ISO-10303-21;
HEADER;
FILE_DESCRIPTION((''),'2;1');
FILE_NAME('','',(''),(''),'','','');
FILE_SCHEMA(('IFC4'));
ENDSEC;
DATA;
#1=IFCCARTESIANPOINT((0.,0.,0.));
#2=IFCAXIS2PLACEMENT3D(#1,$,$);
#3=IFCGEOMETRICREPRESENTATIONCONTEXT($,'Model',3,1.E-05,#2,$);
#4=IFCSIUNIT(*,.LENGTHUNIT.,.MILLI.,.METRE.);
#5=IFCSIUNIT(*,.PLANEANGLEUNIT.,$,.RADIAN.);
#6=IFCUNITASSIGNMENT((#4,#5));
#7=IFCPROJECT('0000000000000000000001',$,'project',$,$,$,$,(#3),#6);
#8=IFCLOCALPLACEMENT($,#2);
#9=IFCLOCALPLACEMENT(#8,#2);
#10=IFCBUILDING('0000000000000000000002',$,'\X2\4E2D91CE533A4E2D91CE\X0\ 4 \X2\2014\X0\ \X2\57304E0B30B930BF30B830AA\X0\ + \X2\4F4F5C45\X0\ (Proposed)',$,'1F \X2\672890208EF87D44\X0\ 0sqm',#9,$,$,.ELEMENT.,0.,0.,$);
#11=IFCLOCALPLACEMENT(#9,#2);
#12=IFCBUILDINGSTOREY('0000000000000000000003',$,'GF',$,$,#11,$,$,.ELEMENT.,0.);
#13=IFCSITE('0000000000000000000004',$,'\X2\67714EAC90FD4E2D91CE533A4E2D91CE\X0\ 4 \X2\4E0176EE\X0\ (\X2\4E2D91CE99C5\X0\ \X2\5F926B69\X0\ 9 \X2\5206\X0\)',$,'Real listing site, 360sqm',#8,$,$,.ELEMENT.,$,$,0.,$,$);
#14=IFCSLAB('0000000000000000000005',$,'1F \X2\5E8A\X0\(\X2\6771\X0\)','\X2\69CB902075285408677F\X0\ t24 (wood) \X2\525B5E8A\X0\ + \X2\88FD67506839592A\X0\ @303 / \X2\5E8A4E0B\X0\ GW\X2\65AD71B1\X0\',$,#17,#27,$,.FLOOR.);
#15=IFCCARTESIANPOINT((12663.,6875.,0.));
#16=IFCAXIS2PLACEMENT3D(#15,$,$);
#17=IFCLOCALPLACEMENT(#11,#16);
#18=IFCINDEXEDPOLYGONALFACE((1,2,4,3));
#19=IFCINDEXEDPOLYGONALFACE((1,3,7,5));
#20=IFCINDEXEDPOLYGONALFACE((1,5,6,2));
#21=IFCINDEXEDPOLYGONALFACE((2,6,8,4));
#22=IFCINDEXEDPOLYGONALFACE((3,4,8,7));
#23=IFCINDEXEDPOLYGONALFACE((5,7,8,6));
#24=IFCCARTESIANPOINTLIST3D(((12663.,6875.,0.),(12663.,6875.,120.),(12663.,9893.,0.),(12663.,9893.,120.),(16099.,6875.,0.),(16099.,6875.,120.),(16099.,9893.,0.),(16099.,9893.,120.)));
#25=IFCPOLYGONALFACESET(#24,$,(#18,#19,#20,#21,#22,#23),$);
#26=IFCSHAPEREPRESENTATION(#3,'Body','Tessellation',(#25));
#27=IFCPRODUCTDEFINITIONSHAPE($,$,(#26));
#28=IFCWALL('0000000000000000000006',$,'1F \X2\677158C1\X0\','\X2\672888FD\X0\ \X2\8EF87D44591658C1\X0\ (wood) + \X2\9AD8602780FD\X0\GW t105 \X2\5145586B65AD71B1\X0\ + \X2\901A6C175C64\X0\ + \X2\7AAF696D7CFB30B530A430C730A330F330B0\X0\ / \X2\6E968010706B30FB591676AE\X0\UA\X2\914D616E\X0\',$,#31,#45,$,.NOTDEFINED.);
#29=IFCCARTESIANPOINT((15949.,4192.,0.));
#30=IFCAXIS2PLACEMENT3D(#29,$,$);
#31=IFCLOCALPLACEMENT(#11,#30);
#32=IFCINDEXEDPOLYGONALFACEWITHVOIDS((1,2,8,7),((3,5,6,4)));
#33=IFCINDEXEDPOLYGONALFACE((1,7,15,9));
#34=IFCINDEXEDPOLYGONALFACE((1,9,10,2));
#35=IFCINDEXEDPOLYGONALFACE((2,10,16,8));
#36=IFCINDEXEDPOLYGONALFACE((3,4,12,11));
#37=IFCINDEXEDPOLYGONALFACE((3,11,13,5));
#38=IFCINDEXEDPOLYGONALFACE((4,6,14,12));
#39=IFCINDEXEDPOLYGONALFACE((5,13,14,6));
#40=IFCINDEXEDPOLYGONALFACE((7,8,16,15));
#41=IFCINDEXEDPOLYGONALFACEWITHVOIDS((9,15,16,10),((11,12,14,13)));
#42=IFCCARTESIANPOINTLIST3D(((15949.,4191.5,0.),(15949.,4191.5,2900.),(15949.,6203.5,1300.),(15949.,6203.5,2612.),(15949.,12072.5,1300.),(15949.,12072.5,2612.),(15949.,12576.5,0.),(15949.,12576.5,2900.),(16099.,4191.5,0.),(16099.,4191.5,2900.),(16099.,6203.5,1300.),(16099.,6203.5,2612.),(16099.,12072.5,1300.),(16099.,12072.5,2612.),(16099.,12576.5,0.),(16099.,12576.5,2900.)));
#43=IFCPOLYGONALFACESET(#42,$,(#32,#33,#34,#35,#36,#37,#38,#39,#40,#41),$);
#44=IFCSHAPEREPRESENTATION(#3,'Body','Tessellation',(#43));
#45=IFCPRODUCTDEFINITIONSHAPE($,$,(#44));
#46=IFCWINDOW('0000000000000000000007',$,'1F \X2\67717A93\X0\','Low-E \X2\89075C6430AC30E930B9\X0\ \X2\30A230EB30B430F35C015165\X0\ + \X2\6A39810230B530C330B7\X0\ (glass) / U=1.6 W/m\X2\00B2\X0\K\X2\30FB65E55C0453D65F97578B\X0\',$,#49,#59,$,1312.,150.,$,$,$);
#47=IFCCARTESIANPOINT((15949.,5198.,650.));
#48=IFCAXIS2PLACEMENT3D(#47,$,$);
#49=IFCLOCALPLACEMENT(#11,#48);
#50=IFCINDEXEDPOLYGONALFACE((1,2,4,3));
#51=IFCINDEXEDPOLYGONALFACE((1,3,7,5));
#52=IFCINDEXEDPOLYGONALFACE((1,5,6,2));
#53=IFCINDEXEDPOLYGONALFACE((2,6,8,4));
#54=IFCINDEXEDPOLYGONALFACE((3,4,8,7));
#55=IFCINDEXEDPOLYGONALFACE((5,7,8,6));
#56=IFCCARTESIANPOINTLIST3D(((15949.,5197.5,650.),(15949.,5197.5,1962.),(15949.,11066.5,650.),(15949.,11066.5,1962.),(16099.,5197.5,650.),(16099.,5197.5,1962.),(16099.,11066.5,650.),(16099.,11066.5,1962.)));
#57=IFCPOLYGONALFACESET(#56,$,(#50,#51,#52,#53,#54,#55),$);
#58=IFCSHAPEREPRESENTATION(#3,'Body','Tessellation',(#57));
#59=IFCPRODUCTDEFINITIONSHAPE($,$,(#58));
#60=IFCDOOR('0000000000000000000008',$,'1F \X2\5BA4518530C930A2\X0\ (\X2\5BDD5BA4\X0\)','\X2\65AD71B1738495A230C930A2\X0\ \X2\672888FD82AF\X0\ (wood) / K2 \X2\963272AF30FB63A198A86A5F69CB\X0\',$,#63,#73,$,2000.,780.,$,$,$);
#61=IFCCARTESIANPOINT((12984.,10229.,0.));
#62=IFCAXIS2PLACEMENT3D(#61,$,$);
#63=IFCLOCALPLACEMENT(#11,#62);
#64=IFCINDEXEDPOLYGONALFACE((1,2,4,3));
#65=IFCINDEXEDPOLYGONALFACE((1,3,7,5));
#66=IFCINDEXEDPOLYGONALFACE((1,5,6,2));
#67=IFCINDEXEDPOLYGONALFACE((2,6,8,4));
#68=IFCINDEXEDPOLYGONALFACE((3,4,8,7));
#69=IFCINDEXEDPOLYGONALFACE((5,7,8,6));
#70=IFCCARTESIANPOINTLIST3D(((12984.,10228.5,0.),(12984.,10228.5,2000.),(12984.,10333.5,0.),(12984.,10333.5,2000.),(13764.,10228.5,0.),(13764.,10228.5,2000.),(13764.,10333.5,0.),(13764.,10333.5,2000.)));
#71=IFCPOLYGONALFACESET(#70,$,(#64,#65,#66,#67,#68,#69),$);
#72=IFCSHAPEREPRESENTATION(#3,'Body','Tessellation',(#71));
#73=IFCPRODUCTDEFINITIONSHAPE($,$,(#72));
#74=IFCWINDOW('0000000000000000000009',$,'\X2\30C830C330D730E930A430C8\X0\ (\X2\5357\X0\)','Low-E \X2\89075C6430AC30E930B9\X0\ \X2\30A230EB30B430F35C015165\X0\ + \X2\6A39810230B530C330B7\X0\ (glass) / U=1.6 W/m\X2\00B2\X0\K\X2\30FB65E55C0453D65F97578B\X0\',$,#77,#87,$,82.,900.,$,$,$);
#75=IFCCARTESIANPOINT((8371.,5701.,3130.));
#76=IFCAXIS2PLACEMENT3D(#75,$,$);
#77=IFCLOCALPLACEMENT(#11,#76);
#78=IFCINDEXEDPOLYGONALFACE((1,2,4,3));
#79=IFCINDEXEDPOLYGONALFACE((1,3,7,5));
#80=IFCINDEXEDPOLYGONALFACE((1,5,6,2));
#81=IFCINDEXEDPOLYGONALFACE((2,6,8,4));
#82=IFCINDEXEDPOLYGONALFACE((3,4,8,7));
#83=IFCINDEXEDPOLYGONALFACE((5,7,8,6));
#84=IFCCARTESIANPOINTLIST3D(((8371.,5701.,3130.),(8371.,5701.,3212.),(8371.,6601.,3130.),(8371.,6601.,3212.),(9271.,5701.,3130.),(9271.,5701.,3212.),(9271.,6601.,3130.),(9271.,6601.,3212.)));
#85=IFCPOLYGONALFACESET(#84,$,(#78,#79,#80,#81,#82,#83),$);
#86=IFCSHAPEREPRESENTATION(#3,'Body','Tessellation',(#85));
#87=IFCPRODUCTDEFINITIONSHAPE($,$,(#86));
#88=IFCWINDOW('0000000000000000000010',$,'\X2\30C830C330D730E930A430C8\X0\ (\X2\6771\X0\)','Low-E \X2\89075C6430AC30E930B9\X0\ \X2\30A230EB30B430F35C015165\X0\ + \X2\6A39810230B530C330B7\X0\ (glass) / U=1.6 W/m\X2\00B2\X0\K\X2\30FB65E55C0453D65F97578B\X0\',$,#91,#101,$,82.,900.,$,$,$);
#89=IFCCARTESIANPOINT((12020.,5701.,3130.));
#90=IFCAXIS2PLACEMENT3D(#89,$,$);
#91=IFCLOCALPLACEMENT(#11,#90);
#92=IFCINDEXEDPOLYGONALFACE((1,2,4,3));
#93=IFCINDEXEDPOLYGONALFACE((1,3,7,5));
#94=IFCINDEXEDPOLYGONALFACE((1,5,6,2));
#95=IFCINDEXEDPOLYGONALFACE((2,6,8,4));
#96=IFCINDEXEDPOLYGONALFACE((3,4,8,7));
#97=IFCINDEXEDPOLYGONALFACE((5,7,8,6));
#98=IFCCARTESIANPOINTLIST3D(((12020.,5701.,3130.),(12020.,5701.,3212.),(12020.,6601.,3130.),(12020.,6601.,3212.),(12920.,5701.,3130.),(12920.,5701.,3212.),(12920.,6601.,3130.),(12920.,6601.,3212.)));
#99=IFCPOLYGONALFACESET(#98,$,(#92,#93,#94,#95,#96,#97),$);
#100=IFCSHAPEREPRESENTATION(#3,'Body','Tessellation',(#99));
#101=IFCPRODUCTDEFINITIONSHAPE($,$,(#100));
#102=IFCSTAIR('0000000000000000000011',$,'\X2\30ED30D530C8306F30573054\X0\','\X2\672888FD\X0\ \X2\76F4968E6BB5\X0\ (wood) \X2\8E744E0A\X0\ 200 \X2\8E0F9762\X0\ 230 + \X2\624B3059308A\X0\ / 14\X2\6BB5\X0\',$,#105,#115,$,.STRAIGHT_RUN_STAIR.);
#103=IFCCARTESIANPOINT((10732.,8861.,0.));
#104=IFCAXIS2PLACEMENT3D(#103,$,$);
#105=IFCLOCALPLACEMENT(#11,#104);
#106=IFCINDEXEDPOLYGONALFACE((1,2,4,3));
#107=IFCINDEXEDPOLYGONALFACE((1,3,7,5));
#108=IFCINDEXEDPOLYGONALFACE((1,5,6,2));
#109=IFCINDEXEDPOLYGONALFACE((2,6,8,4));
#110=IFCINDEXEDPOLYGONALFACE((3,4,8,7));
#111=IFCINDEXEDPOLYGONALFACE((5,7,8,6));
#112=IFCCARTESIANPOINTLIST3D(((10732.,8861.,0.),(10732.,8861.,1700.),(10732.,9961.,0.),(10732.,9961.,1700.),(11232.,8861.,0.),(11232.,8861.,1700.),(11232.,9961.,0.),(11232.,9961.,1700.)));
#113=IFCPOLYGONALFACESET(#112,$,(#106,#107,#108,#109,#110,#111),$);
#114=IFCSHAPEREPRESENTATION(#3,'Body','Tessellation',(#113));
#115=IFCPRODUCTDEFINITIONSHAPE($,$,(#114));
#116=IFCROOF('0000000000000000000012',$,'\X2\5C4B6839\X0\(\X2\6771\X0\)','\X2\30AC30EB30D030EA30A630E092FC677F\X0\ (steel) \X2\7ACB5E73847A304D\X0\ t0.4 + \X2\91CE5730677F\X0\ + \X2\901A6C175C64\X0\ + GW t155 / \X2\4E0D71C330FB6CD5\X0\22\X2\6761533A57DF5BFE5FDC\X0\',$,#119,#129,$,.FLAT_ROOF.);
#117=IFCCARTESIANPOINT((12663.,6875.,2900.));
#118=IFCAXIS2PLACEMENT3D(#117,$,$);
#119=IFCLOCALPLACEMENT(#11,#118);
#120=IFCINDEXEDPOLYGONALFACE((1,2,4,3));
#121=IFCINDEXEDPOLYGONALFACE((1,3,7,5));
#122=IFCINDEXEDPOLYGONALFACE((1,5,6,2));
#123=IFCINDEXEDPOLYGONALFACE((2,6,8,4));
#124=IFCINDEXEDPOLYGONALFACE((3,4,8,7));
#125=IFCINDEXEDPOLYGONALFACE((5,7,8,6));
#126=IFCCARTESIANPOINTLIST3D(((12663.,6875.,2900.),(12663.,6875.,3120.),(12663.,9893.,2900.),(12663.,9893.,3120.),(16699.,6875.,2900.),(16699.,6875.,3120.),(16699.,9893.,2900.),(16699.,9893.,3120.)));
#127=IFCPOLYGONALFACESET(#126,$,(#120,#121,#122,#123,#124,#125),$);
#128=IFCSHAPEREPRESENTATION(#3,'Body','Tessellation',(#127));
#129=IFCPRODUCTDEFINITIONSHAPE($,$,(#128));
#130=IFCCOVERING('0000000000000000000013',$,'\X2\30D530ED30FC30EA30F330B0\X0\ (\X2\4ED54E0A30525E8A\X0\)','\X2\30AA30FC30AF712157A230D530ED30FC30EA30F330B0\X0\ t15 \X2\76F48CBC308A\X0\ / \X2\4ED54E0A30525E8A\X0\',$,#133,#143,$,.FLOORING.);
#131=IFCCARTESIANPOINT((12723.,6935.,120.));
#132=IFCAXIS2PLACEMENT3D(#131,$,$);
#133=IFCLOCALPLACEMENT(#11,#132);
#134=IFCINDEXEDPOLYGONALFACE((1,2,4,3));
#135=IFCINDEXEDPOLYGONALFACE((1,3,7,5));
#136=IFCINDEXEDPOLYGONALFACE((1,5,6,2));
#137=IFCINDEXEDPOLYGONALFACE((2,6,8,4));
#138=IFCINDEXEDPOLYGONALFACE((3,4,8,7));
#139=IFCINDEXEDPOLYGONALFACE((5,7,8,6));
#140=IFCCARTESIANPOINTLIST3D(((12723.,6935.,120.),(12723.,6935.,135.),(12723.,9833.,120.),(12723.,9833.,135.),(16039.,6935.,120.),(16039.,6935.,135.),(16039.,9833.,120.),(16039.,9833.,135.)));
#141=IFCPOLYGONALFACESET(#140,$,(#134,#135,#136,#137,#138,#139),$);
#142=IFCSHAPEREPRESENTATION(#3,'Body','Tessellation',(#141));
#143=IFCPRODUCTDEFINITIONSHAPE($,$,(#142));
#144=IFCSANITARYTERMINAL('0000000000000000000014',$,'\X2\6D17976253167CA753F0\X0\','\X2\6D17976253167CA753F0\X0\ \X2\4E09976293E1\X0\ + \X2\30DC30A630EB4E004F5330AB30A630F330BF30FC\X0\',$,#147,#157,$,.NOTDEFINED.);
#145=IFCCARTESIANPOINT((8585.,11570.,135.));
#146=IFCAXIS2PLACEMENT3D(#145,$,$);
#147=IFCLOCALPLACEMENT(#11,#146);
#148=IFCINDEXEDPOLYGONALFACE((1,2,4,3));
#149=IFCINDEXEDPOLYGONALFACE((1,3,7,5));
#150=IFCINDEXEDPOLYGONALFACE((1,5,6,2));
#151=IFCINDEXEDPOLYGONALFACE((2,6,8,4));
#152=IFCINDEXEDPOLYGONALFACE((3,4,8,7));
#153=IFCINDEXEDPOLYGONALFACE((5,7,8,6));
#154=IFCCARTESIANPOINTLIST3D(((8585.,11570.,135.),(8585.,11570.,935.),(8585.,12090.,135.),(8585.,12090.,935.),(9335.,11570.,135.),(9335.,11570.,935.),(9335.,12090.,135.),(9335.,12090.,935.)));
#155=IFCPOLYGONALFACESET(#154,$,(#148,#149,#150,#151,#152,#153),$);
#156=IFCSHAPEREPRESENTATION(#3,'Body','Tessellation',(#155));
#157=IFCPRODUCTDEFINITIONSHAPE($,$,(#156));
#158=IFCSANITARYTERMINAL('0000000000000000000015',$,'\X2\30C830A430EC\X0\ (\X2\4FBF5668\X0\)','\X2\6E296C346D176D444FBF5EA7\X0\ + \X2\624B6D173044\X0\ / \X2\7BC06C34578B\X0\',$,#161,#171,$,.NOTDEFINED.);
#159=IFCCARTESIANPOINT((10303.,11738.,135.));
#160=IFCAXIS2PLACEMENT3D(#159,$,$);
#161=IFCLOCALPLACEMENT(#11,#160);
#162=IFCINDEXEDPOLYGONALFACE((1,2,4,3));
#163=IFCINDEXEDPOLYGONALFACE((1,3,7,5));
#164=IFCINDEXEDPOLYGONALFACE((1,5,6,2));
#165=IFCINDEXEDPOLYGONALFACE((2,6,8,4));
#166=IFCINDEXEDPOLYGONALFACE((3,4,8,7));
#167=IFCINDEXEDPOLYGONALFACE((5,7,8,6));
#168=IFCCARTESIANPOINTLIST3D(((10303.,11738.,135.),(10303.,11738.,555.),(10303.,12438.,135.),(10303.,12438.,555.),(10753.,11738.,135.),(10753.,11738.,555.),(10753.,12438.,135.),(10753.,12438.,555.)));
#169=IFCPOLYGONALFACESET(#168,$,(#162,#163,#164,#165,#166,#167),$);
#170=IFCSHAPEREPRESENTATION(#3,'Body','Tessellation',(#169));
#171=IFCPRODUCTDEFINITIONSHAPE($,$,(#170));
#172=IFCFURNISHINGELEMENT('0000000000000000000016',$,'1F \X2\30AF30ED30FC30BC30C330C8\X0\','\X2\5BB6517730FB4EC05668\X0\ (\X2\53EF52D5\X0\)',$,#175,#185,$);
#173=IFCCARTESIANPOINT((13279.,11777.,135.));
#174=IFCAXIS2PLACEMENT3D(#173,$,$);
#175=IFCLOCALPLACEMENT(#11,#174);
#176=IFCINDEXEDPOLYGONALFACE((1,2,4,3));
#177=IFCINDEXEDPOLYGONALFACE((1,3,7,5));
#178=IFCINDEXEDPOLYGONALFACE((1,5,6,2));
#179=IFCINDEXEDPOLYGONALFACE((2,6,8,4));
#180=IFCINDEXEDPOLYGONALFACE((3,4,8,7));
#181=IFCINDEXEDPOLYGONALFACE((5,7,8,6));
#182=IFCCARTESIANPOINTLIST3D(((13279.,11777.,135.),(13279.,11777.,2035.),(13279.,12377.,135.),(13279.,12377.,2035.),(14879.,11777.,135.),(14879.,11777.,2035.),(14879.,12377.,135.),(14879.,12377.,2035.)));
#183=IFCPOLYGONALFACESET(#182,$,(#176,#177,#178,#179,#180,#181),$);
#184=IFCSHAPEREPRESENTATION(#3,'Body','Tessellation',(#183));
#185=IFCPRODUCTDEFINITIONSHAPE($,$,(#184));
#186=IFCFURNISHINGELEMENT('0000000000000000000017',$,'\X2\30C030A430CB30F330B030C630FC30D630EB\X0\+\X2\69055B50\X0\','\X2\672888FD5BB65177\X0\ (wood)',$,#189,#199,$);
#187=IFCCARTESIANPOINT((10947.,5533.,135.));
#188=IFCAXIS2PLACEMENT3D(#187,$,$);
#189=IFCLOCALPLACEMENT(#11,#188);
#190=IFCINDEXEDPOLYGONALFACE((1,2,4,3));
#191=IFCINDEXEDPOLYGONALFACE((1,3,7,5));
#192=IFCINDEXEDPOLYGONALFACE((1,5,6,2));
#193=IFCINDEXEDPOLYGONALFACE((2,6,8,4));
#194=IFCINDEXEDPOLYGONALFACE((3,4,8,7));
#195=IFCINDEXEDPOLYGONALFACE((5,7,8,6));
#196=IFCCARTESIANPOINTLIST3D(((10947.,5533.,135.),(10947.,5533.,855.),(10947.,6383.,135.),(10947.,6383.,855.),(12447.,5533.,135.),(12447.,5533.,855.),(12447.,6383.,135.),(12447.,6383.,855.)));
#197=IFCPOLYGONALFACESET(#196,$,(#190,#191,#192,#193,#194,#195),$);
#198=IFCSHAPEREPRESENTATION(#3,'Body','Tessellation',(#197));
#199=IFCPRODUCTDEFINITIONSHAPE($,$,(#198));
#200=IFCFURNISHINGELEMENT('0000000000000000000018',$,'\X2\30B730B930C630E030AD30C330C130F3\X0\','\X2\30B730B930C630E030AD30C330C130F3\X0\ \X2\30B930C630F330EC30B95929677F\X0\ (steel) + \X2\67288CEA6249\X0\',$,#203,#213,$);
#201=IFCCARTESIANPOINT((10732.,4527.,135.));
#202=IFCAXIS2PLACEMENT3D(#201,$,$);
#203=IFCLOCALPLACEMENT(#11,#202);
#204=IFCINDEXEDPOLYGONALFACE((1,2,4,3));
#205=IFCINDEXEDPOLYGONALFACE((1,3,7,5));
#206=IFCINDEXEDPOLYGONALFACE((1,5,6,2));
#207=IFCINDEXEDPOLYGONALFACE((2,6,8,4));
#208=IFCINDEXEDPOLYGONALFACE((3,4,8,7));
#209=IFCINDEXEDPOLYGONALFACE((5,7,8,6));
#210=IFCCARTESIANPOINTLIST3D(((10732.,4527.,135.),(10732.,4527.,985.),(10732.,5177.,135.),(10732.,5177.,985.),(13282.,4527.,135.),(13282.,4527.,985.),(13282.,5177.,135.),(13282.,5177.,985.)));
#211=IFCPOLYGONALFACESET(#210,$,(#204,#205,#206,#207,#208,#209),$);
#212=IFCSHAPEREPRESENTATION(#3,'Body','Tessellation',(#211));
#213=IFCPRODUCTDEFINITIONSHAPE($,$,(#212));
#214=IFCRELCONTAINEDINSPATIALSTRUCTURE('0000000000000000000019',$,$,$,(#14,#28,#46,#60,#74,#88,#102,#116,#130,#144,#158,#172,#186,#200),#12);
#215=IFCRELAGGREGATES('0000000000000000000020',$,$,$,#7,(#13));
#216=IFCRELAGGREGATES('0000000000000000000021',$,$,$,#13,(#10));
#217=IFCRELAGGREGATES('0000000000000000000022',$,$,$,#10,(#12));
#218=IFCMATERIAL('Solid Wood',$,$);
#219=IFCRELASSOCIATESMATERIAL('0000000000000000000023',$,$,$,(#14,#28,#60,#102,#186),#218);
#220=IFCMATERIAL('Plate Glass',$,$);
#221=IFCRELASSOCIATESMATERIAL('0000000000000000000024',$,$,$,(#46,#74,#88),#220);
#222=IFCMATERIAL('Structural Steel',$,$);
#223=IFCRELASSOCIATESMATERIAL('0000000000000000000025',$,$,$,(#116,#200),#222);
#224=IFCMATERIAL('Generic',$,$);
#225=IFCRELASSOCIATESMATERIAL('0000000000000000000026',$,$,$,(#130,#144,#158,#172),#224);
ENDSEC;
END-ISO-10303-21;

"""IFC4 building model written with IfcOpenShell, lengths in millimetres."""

from ifc_helpers import new_model, si_unit, frame, frame_2d, origin, place, context, project, spatial, rectangle, extrude, material, element, fill, save


model = new_model("IFC4")

# Units and contexts
model_context = context("Model", 3, precision=1e-05, world=origin())
ifc_project = project(units=[si_unit("LENGTHUNIT", "METRE", prefix="MILLI"), si_unit("PLANEANGLEUNIT", "RADIAN")], contexts=[model_context])

# Site, building, storey
site_placement = place(None, origin())
site = spatial("IfcSite", under=ifc_project, at=site_placement, Name="東京都中野区中野 4 丁目 (中野駅 徒歩 9 分)", ObjectType="Real listing site, 360sqm", CompositionType="ELEMENT", RefElevation=0.0)
building_placement = place(site_placement, origin())
building = spatial("IfcBuilding", under=site, at=building_placement, Name="中野区中野 4 — 地下スタジオ + 住居 (Proposed)", ObjectType="1F 木造軸組 0sqm", CompositionType="ELEMENT", ElevationOfRefHeight=0.0, ElevationOfTerrain=0.0)
storey_placement = place(building_placement, origin())
storey = spatial("IfcBuildingStorey", under=building, at=storey_placement, Name="GF", CompositionType="ELEMENT", Elevation=0.0)

# Slab
ifc_material_1 = material(Name="Solid Wood")
slab_1_placement = place(storey_placement, frame((12663.0, 6875.0, 0.0)))
element("IfcSlab", 1, at=slab_1_placement, inside=storey, material=ifc_material_1, Name="1F 床(東)", Description="構造用合板 t24 (wood) 剛床 + 製材根太 @303 / 床下 GW断熱", PredefinedType="FLOOR", context=model_context, shape_type="SweptSolid", body=[
    extrude(rectangle(XDim=3436.0, YDim=3018.0, at=frame_2d((1718.0, 1509.0))), frame((12663.0, 6875.0, 0.0)), (0.0, 0.0, 1.0), 120.0),
])

# Wall, opening, window
wall_1_placement = place(storey_placement, frame((15949.0, 4192.0, 0.0)))
wall_1 = element("IfcWall", 2, at=wall_1_placement, inside=storey, material=ifc_material_1, Name="1F 東壁", Description="木製 軸組外壁 (wood) + 高性能GW t105 充填断熱 + 通気層 + 窯業系サイディング / 準耐火・外皮UA配慮", PredefinedType="NOTDEFINED", context=model_context, shape_type="SweptSolid", body=[
    extrude(rectangle(XDim=150.0, YDim=8385.0, at=frame_2d((75.0, 4192.0))), frame((15949.0, 4192.0, 0.0)), (0.0, 0.0, 1.0), 2900.0),
])
opening_1_placement = place(storey_placement, frame((15949.0, 5198.0, 650.0)))
opening_1 = element("IfcOpeningElement", 3, at=opening_1_placement, cuts=wall_1, PredefinedType="NOTDEFINED", context=model_context, shape_type="SweptSolid", body=[
    extrude(rectangle(XDim=150.0, YDim=5869.0, at=frame_2d((75.0, 2934.0))), frame((15949.0, 5198.0, 650.0)), (0.0, 0.0, 1.0), 1312.0),
])
ifc_material_2 = material(Name="Plate Glass")
window_1_placement = place(storey_placement, frame((15949.0, 5198.0, 650.0)))
window_1 = element("IfcWindow", 4, at=window_1_placement, inside=storey, material=ifc_material_2, Name="1F 東窓", Description="Low-E 複層ガラス アルゴン封入 + 樹脂サッシ (glass) / U=1.6 W/m²K・日射取得型", OverallHeight=1312.0, OverallWidth=150.0, context=model_context, shape_type="SweptSolid", body=[
    extrude(rectangle(XDim=150.0, YDim=5869.0, at=frame_2d((75.0, 2934.0))), frame((15949.0, 5198.0, 650.0)), (0.0, 0.0, 1.0), 1312.0),
])
fill(opening_1, window_1)

# Door
door_placement = place(storey_placement, frame((12984.0, 10229.0, 0.0)))
element("IfcDoor", 5, at=door_placement, inside=storey, material=ifc_material_1, Name="1F 室内ドア (寝室)", Description="断熱玄関ドア 木製芯 (wood) / K2 防犯・採風機構", OverallHeight=2000.0, OverallWidth=780.0, context=model_context, shape_type="SweptSolid", body=[
    extrude(rectangle(XDim=780.0, YDim=105.0, at=frame_2d((390.0, 52.0))), frame((12984.0, 10229.0, 0.0)), (0.0, 0.0, 1.0), 2000.0),
])

# Windows
window_2_placement = place(storey_placement, frame((8371.0, 5701.0, 3130.0)))
element("IfcWindow", 6, at=window_2_placement, inside=storey, material=ifc_material_2, Name="トップライト (南)", Description="Low-E 複層ガラス アルゴン封入 + 樹脂サッシ (glass) / U=1.6 W/m²K・日射取得型", OverallHeight=82.0, OverallWidth=900.0, context=model_context, shape_type="SweptSolid", body=[
    extrude(rectangle(XDim=900.0, YDim=900.0, at=frame_2d((450.0, 450.0))), frame((8371.0, 5701.0, 3130.0)), (0.0, 0.0, 1.0), 82.0),
])
window_3_placement = place(storey_placement, frame((12020.0, 5701.0, 3130.0)))
element("IfcWindow", 7, at=window_3_placement, inside=storey, material=ifc_material_2, Name="トップライト (東)", Description="Low-E 複層ガラス アルゴン封入 + 樹脂サッシ (glass) / U=1.6 W/m²K・日射取得型", OverallHeight=82.0, OverallWidth=900.0, context=model_context, shape_type="SweptSolid", body=[
    extrude(rectangle(XDim=900.0, YDim=900.0, at=frame_2d((450.0, 450.0))), frame((12020.0, 5701.0, 3130.0)), (0.0, 0.0, 1.0), 82.0),
])

# Stair
stair_placement = place(storey_placement, frame((10732.0, 8861.0, 0.0)))
element("IfcStair", 8, at=stair_placement, inside=storey, material=ifc_material_1, Name="ロフトはしご", Description="木製 直階段 (wood) 蹴上 200 踏面 230 + 手すり / 14段", PredefinedType="STRAIGHT_RUN_STAIR", context=model_context, shape_type="SweptSolid", body=[
    extrude(rectangle(XDim=500.0, YDim=1100.0, at=frame_2d((250.0, 550.0))), frame((10732.0, 8861.0, 0.0)), (0.0, 0.0, 1.0), 1700.0),
])

# Roof
ifc_material_3 = material(Name="Structural Steel")
roof_placement = place(storey_placement, frame((12663.0, 6875.0, 2900.0)))
element("IfcRoof", 9, at=roof_placement, inside=storey, material=ifc_material_3, Name="屋根(東)", Description="ガルバリウム鋼板 (steel) 立平葺き t0.4 + 野地板 + 通気層 + GW t155 / 不燃・法22条区域対応", PredefinedType="FLAT_ROOF", context=model_context, shape_type="SweptSolid", body=[
    extrude(rectangle(XDim=4036.0, YDim=3018.0, at=frame_2d((2018.0, 1509.0))), frame((12663.0, 6875.0, 2900.0)), (0.0, 0.0, 1.0), 220.0),
])

# Covering
ifc_material_4 = material(Name="Generic")
covering_placement = place(storey_placement, frame((12723.0, 6935.0, 120.0)))
element("IfcCovering", 10, at=covering_placement, inside=storey, material=ifc_material_4, Name="フローリング (仕上げ床)", Description="オーク無垢フローリング t15 直貼り / 仕上げ床", PredefinedType="FLOORING", context=model_context, shape_type="SweptSolid", body=[
    extrude(rectangle(XDim=3316.0, YDim=2898.0, at=frame_2d((1658.0, 1449.0))), frame((12723.0, 6935.0, 120.0)), (0.0, 0.0, 1.0), 15.0),
])

# Sanitary terminals
sanitary_terminal_1_placement = place(storey_placement, frame((8585.0, 11570.0, 135.0)))
element("IfcSanitaryTerminal", 11, at=sanitary_terminal_1_placement, inside=storey, material=ifc_material_4, Name="洗面化粧台", Description="洗面化粧台 三面鏡 + ボウル一体カウンター", PredefinedType="NOTDEFINED", context=model_context, shape_type="SweptSolid", body=[
    extrude(rectangle(XDim=750.0, YDim=520.0, at=frame_2d((375.0, 260.0))), frame((8585.0, 11570.0, 135.0)), (0.0, 0.0, 1.0), 800.0),
])
sanitary_terminal_2_placement = place(storey_placement, frame((10303.0, 11738.0, 135.0)))
element("IfcSanitaryTerminal", 12, at=sanitary_terminal_2_placement, inside=storey, material=ifc_material_4, Name="トイレ (便器)", Description="温水洗浄便座 + 手洗い / 節水型", PredefinedType="NOTDEFINED", context=model_context, shape_type="SweptSolid", body=[
    extrude(rectangle(XDim=450.0, YDim=700.0, at=frame_2d((225.0, 350.0))), frame((10303.0, 11738.0, 135.0)), (0.0, 0.0, 1.0), 420.0),
])

# Furnishing elements
furnishing_1_placement = place(storey_placement, frame((13279.0, 11777.0, 135.0)))
element("IfcFurnishingElement", 13, at=furnishing_1_placement, inside=storey, material=ifc_material_4, Name="1F クローゼット", Description="家具・什器 (可動)", context=model_context, shape_type="SweptSolid", body=[
    extrude(rectangle(XDim=1600.0, YDim=600.0, at=frame_2d((800.0, 300.0))), frame((13279.0, 11777.0, 135.0)), (0.0, 0.0, 1.0), 1900.0),
])
furnishing_2_placement = place(storey_placement, frame((10947.0, 5533.0, 135.0)))
element("IfcFurnishingElement", 14, at=furnishing_2_placement, inside=storey, material=ifc_material_1, Name="ダイニングテーブル+椅子", Description="木製家具 (wood)", context=model_context, shape_type="SweptSolid", body=[
    extrude(rectangle(XDim=1500.0, YDim=850.0, at=frame_2d((750.0, 425.0))), frame((10947.0, 5533.0, 135.0)), (0.0, 0.0, 1.0), 720.0),
])
furnishing_3_placement = place(storey_placement, frame((10732.0, 4527.0, 135.0)))
element("IfcFurnishingElement", 15, at=furnishing_3_placement, inside=storey, material=ifc_material_3, Name="システムキッチン", Description="システムキッチン ステンレス天板 (steel) + 木質扉", context=model_context, shape_type="SweptSolid", body=[
    extrude(rectangle(XDim=2550.0, YDim=650.0, at=frame_2d((1275.0, 325.0))), frame((10732.0, 4527.0, 135.0)), (0.0, 0.0, 1.0), 850.0),
])

save(model, "model.ifc")
